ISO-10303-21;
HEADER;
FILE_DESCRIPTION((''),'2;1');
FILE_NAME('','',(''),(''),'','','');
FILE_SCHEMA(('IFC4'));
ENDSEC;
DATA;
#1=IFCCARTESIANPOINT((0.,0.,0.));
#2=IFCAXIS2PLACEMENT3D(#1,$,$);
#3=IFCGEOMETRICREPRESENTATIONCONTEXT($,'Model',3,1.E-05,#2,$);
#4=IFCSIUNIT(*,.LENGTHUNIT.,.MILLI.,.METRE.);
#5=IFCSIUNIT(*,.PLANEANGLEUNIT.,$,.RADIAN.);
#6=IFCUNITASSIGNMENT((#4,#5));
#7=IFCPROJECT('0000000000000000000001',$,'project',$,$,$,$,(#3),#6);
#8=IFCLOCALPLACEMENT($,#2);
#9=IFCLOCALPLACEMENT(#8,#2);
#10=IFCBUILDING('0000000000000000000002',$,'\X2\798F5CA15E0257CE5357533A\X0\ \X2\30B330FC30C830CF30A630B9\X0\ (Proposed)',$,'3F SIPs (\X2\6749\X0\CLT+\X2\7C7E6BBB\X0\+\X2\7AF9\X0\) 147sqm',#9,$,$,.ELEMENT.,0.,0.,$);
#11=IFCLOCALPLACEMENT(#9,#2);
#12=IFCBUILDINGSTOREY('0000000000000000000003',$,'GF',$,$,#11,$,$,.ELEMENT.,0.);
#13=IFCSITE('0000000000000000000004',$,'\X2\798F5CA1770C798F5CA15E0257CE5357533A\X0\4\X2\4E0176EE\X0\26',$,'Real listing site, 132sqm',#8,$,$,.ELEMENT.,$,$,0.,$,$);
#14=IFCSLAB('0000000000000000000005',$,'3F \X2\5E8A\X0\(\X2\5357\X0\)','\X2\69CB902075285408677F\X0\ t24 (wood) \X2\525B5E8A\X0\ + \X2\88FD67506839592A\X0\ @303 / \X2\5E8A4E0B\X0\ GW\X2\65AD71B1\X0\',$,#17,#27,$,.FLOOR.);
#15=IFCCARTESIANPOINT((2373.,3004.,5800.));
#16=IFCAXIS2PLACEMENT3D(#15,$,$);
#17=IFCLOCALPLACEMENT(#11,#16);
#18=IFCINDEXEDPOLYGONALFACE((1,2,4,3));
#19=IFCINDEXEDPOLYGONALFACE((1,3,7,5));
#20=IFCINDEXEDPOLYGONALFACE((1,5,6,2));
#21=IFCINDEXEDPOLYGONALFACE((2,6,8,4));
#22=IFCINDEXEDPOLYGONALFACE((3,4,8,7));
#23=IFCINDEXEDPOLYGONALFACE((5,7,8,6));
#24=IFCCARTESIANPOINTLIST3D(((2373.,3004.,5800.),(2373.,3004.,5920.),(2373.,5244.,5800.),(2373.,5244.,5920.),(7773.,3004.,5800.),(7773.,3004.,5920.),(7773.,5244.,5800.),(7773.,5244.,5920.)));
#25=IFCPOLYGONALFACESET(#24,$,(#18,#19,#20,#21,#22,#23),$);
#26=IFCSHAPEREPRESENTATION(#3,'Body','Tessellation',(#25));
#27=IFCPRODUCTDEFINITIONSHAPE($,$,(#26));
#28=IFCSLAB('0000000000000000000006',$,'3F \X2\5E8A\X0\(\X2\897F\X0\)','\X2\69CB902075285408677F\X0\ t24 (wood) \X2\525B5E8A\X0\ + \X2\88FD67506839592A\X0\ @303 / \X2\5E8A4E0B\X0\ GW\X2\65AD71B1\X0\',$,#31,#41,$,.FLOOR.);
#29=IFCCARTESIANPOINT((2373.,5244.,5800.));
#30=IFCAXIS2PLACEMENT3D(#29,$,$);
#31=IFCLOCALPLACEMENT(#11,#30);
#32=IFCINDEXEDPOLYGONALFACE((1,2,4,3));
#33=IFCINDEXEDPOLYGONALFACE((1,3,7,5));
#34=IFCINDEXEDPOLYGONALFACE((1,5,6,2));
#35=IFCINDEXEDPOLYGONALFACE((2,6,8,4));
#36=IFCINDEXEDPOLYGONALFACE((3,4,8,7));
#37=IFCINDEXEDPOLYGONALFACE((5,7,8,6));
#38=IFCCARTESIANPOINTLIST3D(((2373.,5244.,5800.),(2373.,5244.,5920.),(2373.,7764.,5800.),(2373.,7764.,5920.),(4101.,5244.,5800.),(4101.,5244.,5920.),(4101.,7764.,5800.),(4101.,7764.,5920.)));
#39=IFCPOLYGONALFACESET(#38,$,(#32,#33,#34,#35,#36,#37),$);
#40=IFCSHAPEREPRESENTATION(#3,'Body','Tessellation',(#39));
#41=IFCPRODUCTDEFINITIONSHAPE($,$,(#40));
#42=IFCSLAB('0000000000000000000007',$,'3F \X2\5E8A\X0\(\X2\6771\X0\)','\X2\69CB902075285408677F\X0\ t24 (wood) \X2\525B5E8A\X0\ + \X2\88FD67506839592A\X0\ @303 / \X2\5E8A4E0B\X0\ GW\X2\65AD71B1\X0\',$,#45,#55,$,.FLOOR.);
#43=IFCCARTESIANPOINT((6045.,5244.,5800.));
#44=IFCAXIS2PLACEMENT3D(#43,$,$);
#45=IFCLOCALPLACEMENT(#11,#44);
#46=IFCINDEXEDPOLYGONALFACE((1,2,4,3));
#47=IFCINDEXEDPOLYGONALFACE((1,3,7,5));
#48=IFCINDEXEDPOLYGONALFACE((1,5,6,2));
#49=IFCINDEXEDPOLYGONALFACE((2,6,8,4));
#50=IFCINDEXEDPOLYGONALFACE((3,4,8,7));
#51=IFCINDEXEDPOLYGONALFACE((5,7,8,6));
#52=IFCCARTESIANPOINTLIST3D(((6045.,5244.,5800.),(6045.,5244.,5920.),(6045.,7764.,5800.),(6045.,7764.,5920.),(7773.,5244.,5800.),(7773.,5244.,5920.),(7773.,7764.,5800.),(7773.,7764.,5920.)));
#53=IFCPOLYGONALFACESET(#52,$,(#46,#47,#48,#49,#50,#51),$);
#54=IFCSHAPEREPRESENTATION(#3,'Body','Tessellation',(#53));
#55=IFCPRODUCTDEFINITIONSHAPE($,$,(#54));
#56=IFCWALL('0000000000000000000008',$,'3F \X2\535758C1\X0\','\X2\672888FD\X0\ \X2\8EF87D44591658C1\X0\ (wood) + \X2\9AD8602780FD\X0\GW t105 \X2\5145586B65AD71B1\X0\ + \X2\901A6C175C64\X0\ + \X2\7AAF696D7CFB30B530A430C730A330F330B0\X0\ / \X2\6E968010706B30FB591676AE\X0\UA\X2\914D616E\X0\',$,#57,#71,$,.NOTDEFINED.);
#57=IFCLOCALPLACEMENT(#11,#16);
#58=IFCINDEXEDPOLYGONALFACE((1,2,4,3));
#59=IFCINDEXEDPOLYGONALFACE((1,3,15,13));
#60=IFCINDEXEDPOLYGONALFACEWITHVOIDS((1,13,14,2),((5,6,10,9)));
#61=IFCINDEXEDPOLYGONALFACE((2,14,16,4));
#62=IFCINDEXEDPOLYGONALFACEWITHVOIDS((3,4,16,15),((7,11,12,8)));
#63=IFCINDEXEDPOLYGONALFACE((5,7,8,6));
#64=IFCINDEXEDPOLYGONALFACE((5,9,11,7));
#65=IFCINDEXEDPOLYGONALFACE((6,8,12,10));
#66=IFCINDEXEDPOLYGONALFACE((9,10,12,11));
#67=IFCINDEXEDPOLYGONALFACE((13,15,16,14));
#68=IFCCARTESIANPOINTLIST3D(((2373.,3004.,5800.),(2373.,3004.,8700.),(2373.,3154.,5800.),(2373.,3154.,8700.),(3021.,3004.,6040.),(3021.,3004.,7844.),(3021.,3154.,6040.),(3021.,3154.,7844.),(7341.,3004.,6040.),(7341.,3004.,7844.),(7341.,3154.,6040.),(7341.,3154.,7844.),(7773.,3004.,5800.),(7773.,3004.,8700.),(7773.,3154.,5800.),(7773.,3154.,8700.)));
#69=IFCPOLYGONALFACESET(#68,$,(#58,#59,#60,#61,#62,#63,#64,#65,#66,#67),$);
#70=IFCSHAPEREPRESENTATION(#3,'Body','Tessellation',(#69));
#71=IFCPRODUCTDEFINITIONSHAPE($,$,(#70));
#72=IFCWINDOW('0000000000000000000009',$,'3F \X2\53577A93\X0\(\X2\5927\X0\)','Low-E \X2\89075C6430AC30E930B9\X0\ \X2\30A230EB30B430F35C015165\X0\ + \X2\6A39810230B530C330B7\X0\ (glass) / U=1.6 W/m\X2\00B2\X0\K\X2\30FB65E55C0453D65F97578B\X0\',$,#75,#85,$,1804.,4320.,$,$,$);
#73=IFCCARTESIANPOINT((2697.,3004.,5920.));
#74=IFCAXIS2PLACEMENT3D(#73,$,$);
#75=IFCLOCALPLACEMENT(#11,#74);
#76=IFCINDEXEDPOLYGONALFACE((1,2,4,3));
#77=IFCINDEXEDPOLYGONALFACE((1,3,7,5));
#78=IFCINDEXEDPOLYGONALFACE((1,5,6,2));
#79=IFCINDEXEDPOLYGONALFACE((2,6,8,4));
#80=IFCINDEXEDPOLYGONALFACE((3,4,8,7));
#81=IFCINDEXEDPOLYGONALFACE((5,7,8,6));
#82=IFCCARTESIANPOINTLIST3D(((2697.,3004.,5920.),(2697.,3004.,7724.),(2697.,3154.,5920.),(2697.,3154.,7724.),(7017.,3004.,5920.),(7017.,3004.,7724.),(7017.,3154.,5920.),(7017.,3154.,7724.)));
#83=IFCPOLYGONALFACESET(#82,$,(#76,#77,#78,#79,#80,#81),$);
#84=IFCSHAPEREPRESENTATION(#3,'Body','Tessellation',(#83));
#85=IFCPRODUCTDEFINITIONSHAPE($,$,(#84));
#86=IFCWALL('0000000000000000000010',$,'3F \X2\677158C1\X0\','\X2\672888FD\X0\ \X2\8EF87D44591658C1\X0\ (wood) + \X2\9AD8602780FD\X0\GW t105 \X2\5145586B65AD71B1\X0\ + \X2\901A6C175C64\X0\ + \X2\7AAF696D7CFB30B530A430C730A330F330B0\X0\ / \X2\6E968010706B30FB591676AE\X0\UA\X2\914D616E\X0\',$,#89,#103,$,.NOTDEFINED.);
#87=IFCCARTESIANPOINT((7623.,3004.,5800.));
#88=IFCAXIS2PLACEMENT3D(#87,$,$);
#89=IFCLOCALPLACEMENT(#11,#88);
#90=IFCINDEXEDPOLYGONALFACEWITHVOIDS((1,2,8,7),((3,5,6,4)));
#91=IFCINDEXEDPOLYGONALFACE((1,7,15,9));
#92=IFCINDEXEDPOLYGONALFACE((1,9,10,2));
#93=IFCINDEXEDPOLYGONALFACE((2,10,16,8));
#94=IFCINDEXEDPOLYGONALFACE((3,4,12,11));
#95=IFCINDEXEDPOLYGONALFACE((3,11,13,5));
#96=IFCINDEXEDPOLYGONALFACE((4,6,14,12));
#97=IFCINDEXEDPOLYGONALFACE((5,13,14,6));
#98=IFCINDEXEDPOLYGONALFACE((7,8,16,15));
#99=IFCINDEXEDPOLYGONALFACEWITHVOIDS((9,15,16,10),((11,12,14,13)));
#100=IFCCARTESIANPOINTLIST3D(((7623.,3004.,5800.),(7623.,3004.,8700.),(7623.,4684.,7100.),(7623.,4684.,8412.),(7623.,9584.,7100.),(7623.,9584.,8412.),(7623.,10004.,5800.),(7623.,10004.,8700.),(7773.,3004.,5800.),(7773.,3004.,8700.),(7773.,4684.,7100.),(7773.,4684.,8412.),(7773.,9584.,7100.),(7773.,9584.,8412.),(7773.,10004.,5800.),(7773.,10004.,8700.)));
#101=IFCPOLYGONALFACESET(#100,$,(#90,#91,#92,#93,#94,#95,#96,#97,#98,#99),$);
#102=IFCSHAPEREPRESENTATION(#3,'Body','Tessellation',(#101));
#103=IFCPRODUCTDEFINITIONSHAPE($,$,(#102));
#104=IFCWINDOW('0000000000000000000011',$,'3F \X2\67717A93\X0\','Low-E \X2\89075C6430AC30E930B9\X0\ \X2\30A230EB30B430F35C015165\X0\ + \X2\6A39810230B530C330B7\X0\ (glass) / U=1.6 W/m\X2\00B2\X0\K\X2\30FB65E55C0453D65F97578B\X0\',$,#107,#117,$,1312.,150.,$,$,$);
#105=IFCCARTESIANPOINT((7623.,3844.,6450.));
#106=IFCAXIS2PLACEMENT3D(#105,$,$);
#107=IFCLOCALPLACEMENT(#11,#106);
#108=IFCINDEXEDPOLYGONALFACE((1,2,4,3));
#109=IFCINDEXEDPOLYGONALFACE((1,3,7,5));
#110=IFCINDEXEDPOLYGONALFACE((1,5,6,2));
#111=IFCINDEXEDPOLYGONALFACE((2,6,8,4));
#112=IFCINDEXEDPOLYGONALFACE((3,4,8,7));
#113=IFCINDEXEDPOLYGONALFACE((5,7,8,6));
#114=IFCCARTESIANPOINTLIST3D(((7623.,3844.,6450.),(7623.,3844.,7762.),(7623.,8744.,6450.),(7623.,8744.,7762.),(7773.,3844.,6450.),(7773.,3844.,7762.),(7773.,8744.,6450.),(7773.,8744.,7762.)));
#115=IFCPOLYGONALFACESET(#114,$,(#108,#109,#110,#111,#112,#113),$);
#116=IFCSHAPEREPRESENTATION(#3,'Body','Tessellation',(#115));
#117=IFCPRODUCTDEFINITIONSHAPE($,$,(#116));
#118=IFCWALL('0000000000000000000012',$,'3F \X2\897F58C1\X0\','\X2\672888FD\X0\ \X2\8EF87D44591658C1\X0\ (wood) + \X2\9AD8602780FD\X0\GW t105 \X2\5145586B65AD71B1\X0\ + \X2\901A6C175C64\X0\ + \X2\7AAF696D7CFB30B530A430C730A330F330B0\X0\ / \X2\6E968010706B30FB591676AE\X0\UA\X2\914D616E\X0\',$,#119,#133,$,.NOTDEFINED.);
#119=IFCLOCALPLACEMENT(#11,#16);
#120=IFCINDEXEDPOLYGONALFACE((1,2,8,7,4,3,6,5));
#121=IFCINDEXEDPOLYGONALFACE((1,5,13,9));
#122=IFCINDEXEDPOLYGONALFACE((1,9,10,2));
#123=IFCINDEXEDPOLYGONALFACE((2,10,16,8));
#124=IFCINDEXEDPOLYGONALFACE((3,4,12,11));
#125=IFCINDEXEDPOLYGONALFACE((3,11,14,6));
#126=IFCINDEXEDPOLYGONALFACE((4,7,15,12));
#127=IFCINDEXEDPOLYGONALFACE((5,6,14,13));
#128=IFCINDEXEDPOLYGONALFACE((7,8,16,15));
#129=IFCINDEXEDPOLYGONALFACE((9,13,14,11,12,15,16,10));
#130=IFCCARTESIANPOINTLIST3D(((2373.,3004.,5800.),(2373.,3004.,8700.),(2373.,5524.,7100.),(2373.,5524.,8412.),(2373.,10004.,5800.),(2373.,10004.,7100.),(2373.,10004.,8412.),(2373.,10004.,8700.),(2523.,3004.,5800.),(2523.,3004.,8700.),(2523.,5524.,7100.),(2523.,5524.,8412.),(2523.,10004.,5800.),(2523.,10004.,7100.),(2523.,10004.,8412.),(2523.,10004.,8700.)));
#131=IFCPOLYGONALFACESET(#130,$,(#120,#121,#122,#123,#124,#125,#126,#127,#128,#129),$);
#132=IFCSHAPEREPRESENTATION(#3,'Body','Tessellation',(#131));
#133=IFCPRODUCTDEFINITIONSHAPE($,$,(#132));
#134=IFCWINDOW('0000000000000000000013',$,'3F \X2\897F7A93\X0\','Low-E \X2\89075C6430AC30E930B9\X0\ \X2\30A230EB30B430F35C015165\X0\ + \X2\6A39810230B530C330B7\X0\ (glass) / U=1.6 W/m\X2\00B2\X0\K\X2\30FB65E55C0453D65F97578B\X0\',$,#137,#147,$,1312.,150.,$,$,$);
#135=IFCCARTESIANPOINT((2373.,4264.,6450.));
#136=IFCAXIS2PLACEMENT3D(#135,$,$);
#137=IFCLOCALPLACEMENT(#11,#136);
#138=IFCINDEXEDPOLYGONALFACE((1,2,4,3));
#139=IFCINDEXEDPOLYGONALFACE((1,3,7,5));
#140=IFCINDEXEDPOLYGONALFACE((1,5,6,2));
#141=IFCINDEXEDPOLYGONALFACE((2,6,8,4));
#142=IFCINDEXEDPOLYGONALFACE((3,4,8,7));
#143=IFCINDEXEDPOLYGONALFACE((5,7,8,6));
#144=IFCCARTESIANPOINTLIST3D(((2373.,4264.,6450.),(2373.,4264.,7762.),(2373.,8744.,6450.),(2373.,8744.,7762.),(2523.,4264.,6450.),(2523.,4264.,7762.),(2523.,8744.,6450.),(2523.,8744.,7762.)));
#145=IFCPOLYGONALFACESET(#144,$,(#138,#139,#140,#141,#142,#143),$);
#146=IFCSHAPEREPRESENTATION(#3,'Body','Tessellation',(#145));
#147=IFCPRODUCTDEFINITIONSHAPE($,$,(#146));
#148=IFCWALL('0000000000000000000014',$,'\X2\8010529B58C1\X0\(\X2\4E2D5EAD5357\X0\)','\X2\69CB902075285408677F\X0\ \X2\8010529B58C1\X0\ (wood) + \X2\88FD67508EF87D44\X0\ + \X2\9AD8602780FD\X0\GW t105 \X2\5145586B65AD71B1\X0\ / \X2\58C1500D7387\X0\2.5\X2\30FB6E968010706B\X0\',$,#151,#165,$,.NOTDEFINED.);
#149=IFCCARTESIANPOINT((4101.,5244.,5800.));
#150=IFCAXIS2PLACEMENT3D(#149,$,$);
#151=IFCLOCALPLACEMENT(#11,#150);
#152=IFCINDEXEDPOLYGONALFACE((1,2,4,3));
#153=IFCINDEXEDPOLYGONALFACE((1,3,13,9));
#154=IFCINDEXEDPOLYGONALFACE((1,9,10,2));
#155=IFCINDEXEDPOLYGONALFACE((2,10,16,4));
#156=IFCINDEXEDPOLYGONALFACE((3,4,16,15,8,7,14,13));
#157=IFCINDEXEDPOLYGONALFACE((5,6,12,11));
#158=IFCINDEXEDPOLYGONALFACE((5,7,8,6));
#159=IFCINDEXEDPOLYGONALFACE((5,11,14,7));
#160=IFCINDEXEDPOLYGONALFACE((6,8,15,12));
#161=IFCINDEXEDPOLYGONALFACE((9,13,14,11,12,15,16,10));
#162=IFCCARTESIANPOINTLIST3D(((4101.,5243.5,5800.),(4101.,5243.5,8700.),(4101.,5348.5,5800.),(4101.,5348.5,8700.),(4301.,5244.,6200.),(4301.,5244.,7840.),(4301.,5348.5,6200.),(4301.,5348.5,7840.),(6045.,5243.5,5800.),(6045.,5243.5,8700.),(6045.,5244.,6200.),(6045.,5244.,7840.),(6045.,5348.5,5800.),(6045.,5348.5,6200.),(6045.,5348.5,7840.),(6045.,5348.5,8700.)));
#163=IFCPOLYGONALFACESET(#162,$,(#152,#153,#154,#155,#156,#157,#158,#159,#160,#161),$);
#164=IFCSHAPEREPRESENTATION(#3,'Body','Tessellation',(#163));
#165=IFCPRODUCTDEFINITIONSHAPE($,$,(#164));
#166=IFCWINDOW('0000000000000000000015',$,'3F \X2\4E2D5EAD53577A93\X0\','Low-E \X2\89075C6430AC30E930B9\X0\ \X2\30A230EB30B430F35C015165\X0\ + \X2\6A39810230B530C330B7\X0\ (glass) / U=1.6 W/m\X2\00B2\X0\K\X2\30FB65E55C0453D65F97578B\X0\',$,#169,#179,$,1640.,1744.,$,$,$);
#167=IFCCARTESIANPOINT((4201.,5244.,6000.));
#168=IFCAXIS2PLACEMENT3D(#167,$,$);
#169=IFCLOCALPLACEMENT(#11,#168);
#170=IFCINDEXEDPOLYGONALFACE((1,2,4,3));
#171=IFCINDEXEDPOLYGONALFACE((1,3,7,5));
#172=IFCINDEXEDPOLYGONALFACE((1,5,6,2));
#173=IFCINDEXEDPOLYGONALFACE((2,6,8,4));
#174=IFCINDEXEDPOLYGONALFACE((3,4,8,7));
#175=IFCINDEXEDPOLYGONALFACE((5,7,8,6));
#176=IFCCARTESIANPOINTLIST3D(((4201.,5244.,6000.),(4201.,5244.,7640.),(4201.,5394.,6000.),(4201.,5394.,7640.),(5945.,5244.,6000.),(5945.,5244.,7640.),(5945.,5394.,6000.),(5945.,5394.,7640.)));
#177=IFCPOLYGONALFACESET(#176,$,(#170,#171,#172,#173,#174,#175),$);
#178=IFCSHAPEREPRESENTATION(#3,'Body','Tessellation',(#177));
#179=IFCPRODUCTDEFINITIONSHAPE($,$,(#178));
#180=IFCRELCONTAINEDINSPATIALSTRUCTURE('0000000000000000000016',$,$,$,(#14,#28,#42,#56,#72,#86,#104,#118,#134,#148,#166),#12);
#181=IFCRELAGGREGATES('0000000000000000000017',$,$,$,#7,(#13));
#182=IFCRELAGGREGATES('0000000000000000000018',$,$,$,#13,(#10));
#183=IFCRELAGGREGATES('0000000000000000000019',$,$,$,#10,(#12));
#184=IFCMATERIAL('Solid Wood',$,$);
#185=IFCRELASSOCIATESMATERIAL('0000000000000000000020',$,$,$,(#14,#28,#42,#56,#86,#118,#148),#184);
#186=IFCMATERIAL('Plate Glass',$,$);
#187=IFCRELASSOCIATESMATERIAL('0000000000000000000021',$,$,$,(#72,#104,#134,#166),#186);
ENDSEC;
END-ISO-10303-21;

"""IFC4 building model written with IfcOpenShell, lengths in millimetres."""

from ifc_helpers import new_model, si_unit, frame, frame_2d, origin, place, context, project, spatial, rectangle, extrude, material, element, fill, save


model = new_model("IFC4")

# Units and contexts
model_context = context("Model", 3, precision=1e-05, world=origin())
ifc_project = project(units=[si_unit("LENGTHUNIT", "METRE", prefix="MILLI"), si_unit("PLANEANGLEUNIT", "RADIAN")], contexts=[model_context])

# Site, building, storey
site_placement = place(None, origin())
site = spatial("IfcSite", under=ifc_project, at=site_placement, Name="福岡県福岡市城南区4丁目26", ObjectType="Real listing site, 132sqm", CompositionType="ELEMENT", RefElevation=0.0)
building_placement = place(site_placement, origin())
building = spatial("IfcBuilding", under=site, at=building_placement, Name="福岡市城南区 コートハウス (Proposed)", ObjectType="3F SIPs (杉CLT+籾殻+竹) 147sqm", CompositionType="ELEMENT", ElevationOfRefHeight=0.0, ElevationOfTerrain=0.0)
storey_placement = place(building_placement, origin())
storey = spatial("IfcBuildingStorey", under=building, at=storey_placement, Name="GF", CompositionType="ELEMENT", Elevation=0.0)

# Slabs
ifc_material_1 = material(Name="Solid Wood")
slab_1_placement = place(storey_placement, frame((2373.0, 3004.0, 5800.0)))
element("IfcSlab", 1, at=slab_1_placement, inside=storey, material=ifc_material_1, Name="3F 床(南)", Description="構造用合板 t24 (wood) 剛床 + 製材根太 @303 / 床下 GW断熱", PredefinedType="FLOOR", context=model_context, shape_type="SweptSolid", body=[
    extrude(rectangle(XDim=5400.0, YDim=2240.0, at=frame_2d((2700.0, 1120.0))), frame((2373.0, 3004.0, 5800.0)), (0.0, 0.0, 1.0), 120.0),
])
slab_2_placement = place(storey_placement, frame((2373.0, 5244.0, 5800.0)))
element("IfcSlab", 2, at=slab_2_placement, inside=storey, material=ifc_material_1, Name="3F 床(西)", Description="構造用合板 t24 (wood) 剛床 + 製材根太 @303 / 床下 GW断熱", PredefinedType="FLOOR", context=model_context, shape_type="SweptSolid", body=[
    extrude(rectangle(XDim=1728.0, YDim=2520.0, at=frame_2d((864.0, 1260.0))), frame((2373.0, 5244.0, 5800.0)), (0.0, 0.0, 1.0), 120.0),
])
slab_3_placement = place(storey_placement, frame((6045.0, 5244.0, 5800.0)))
element("IfcSlab", 3, at=slab_3_placement, inside=storey, material=ifc_material_1, Name="3F 床(東)", Description="構造用合板 t24 (wood) 剛床 + 製材根太 @303 / 床下 GW断熱", PredefinedType="FLOOR", context=model_context, shape_type="SweptSolid", body=[
    extrude(rectangle(XDim=1728.0, YDim=2520.0, at=frame_2d((864.0, 1260.0))), frame((6045.0, 5244.0, 5800.0)), (0.0, 0.0, 1.0), 120.0),
])

# Walls, openings, windows
wall_1_placement = place(storey_placement, frame((2373.0, 3004.0, 5800.0)))
wall_1 = element("IfcWall", 4, at=wall_1_placement, inside=storey, material=ifc_material_1, Name="3F 南壁", Description="木製 軸組外壁 (wood) + 高性能GW t105 充填断熱 + 通気層 + 窯業系サイディング / 準耐火・外皮UA配慮", PredefinedType="NOTDEFINED", context=model_context, shape_type="SweptSolid", body=[
    extrude(rectangle(XDim=5400.0, YDim=150.0, at=frame_2d((2700.0, 75.0))), frame((2373.0, 3004.0, 5800.0)), (0.0, 0.0, 1.0), 2900.0),
])
opening_1_placement = place(storey_placement, frame((2697.0, 3004.0, 5920.0)))
opening_1 = element("IfcOpeningElement", 5, at=opening_1_placement, cuts=wall_1, PredefinedType="NOTDEFINED", context=model_context, shape_type="SweptSolid", body=[
    extrude(rectangle(XDim=4320.0, YDim=150.0, at=frame_2d((2160.0, 75.0))), frame((2697.0, 3004.0, 5920.0)), (0.0, 0.0, 1.0), 1804.0),
])
ifc_material_2 = material(Name="Plate Glass")
window_1_placement = place(storey_placement, frame((2697.0, 3004.0, 5920.0)))
window_1 = element("IfcWindow", 6, at=window_1_placement, inside=storey, material=ifc_material_2, Name="3F 南窓(大)", Description="Low-E 複層ガラス アルゴン封入 + 樹脂サッシ (glass) / U=1.6 W/m²K・日射取得型", OverallHeight=1804.0, OverallWidth=4320.0, context=model_context, shape_type="SweptSolid", body=[
    extrude(rectangle(XDim=4320.0, YDim=150.0, at=frame_2d((2160.0, 75.0))), frame((2697.0, 3004.0, 5920.0)), (0.0, 0.0, 1.0), 1804.0),
])
fill(opening_1, window_1)
wall_2_placement = place(storey_placement, frame((7623.0, 3004.0, 5800.0)))
wall_2 = element("IfcWall", 7, at=wall_2_placement, inside=storey, material=ifc_material_1, Name="3F 東壁", Description="木製 軸組外壁 (wood) + 高性能GW t105 充填断熱 + 通気層 + 窯業系サイディング / 準耐火・外皮UA配慮", PredefinedType="NOTDEFINED", context=model_context, shape_type="SweptSolid", body=[
    extrude(rectangle(XDim=150.0, YDim=7000.0, at=frame_2d((75.0, 3500.0))), frame((7623.0, 3004.0, 5800.0)), (0.0, 0.0, 1.0), 2900.0),
])
opening_2_placement = place(storey_placement, frame((7623.0, 3844.0, 6450.0)))
opening_2 = element("IfcOpeningElement", 8, at=opening_2_placement, cuts=wall_2, PredefinedType="NOTDEFINED", context=model_context, shape_type="SweptSolid", body=[
    extrude(rectangle(XDim=150.0, YDim=4900.0, at=frame_2d((75.0, 2450.0))), frame((7623.0, 3844.0, 6450.0)), (0.0, 0.0, 1.0), 1312.0),
])
window_2_placement = place(storey_placement, frame((7623.0, 3844.0, 6450.0)))
window_2 = element("IfcWindow", 9, at=window_2_placement, inside=storey, material=ifc_material_2, Name="3F 東窓", Description="Low-E 複層ガラス アルゴン封入 + 樹脂サッシ (glass) / U=1.6 W/m²K・日射取得型", OverallHeight=1312.0, OverallWidth=150.0, context=model_context, shape_type="SweptSolid", body=[
    extrude(rectangle(XDim=150.0, YDim=4900.0, at=frame_2d((75.0, 2450.0))), frame((7623.0, 3844.0, 6450.0)), (0.0, 0.0, 1.0), 1312.0),
])
fill(opening_2, window_2)
wall_3_placement = place(storey_placement, frame((2373.0, 3004.0, 5800.0)))
wall_3 = element("IfcWall", 10, at=wall_3_placement, inside=storey, material=ifc_material_1, Name="3F 西壁", Description="木製 軸組外壁 (wood) + 高性能GW t105 充填断熱 + 通気層 + 窯業系サイディング / 準耐火・外皮UA配慮", PredefinedType="NOTDEFINED", context=model_context, shape_type="SweptSolid", body=[
    extrude(rectangle(XDim=150.0, YDim=7000.0, at=frame_2d((75.0, 3500.0))), frame((2373.0, 3004.0, 5800.0)), (0.0, 0.0, 1.0), 2900.0),
])
opening_3_placement = place(storey_placement, frame((2373.0, 4264.0, 6450.0)))
opening_3 = element("IfcOpeningElement", 11, at=opening_3_placement, cuts=wall_3, PredefinedType="NOTDEFINED", context=model_context, shape_type="SweptSolid", body=[
    extrude(rectangle(XDim=150.0, YDim=4480.0, at=frame_2d((75.0, 2240.0))), frame((2373.0, 4264.0, 6450.0)), (0.0, 0.0, 1.0), 1312.0),
])
window_3_placement = place(storey_placement, frame((2373.0, 4264.0, 6450.0)))
window_3 = element("IfcWindow", 12, at=window_3_placement, inside=storey, material=ifc_material_2, Name="3F 西窓", Description="Low-E 複層ガラス アルゴン封入 + 樹脂サッシ (glass) / U=1.6 W/m²K・日射取得型", OverallHeight=1312.0, OverallWidth=150.0, context=model_context, shape_type="SweptSolid", body=[
    extrude(rectangle(XDim=150.0, YDim=4480.0, at=frame_2d((75.0, 2240.0))), frame((2373.0, 4264.0, 6450.0)), (0.0, 0.0, 1.0), 1312.0),
])
fill(opening_3, window_3)
wall_4_placement = place(storey_placement, frame((4101.0, 5244.0, 5800.0)))
wall_4 = element("IfcWall", 13, at=wall_4_placement, inside=storey, material=ifc_material_1, Name="耐力壁(中庭南)", Description="構造用合板 耐力壁 (wood) + 製材軸組 + 高性能GW t105 充填断熱 / 壁倍率2.5・準耐火", PredefinedType="NOTDEFINED", context=model_context, shape_type="SweptSolid", body=[
    extrude(rectangle(XDim=1944.0, YDim=105.0, at=frame_2d((972.0, 52.0))), frame((4101.0, 5244.0, 5800.0)), (0.0, 0.0, 1.0), 2900.0),
])
opening_4_placement = place(storey_placement, frame((4201.0, 5244.0, 6000.0)))
opening_4 = element("IfcOpeningElement", 14, at=opening_4_placement, cuts=wall_4, PredefinedType="NOTDEFINED", context=model_context, shape_type="SweptSolid", body=[
    extrude(rectangle(XDim=1744.0, YDim=150.0, at=frame_2d((872.0, 75.0))), frame((4201.0, 5244.0, 6000.0)), (0.0, 0.0, 1.0), 1640.0),
])
window_4_placement = place(storey_placement, frame((4201.0, 5244.0, 6000.0)))
window_4 = element("IfcWindow", 15, at=window_4_placement, inside=storey, material=ifc_material_2, Name="3F 中庭南窓", Description="Low-E 複層ガラス アルゴン封入 + 樹脂サッシ (glass) / U=1.6 W/m²K・日射取得型", OverallHeight=1640.0, OverallWidth=1744.0, context=model_context, shape_type="SweptSolid", body=[
    extrude(rectangle(XDim=1744.0, YDim=150.0, at=frame_2d((872.0, 75.0))), frame((4201.0, 5244.0, 6000.0)), (0.0, 0.0, 1.0), 1640.0),
])
fill(opening_4, window_4)

save(model, "model.ifc")
